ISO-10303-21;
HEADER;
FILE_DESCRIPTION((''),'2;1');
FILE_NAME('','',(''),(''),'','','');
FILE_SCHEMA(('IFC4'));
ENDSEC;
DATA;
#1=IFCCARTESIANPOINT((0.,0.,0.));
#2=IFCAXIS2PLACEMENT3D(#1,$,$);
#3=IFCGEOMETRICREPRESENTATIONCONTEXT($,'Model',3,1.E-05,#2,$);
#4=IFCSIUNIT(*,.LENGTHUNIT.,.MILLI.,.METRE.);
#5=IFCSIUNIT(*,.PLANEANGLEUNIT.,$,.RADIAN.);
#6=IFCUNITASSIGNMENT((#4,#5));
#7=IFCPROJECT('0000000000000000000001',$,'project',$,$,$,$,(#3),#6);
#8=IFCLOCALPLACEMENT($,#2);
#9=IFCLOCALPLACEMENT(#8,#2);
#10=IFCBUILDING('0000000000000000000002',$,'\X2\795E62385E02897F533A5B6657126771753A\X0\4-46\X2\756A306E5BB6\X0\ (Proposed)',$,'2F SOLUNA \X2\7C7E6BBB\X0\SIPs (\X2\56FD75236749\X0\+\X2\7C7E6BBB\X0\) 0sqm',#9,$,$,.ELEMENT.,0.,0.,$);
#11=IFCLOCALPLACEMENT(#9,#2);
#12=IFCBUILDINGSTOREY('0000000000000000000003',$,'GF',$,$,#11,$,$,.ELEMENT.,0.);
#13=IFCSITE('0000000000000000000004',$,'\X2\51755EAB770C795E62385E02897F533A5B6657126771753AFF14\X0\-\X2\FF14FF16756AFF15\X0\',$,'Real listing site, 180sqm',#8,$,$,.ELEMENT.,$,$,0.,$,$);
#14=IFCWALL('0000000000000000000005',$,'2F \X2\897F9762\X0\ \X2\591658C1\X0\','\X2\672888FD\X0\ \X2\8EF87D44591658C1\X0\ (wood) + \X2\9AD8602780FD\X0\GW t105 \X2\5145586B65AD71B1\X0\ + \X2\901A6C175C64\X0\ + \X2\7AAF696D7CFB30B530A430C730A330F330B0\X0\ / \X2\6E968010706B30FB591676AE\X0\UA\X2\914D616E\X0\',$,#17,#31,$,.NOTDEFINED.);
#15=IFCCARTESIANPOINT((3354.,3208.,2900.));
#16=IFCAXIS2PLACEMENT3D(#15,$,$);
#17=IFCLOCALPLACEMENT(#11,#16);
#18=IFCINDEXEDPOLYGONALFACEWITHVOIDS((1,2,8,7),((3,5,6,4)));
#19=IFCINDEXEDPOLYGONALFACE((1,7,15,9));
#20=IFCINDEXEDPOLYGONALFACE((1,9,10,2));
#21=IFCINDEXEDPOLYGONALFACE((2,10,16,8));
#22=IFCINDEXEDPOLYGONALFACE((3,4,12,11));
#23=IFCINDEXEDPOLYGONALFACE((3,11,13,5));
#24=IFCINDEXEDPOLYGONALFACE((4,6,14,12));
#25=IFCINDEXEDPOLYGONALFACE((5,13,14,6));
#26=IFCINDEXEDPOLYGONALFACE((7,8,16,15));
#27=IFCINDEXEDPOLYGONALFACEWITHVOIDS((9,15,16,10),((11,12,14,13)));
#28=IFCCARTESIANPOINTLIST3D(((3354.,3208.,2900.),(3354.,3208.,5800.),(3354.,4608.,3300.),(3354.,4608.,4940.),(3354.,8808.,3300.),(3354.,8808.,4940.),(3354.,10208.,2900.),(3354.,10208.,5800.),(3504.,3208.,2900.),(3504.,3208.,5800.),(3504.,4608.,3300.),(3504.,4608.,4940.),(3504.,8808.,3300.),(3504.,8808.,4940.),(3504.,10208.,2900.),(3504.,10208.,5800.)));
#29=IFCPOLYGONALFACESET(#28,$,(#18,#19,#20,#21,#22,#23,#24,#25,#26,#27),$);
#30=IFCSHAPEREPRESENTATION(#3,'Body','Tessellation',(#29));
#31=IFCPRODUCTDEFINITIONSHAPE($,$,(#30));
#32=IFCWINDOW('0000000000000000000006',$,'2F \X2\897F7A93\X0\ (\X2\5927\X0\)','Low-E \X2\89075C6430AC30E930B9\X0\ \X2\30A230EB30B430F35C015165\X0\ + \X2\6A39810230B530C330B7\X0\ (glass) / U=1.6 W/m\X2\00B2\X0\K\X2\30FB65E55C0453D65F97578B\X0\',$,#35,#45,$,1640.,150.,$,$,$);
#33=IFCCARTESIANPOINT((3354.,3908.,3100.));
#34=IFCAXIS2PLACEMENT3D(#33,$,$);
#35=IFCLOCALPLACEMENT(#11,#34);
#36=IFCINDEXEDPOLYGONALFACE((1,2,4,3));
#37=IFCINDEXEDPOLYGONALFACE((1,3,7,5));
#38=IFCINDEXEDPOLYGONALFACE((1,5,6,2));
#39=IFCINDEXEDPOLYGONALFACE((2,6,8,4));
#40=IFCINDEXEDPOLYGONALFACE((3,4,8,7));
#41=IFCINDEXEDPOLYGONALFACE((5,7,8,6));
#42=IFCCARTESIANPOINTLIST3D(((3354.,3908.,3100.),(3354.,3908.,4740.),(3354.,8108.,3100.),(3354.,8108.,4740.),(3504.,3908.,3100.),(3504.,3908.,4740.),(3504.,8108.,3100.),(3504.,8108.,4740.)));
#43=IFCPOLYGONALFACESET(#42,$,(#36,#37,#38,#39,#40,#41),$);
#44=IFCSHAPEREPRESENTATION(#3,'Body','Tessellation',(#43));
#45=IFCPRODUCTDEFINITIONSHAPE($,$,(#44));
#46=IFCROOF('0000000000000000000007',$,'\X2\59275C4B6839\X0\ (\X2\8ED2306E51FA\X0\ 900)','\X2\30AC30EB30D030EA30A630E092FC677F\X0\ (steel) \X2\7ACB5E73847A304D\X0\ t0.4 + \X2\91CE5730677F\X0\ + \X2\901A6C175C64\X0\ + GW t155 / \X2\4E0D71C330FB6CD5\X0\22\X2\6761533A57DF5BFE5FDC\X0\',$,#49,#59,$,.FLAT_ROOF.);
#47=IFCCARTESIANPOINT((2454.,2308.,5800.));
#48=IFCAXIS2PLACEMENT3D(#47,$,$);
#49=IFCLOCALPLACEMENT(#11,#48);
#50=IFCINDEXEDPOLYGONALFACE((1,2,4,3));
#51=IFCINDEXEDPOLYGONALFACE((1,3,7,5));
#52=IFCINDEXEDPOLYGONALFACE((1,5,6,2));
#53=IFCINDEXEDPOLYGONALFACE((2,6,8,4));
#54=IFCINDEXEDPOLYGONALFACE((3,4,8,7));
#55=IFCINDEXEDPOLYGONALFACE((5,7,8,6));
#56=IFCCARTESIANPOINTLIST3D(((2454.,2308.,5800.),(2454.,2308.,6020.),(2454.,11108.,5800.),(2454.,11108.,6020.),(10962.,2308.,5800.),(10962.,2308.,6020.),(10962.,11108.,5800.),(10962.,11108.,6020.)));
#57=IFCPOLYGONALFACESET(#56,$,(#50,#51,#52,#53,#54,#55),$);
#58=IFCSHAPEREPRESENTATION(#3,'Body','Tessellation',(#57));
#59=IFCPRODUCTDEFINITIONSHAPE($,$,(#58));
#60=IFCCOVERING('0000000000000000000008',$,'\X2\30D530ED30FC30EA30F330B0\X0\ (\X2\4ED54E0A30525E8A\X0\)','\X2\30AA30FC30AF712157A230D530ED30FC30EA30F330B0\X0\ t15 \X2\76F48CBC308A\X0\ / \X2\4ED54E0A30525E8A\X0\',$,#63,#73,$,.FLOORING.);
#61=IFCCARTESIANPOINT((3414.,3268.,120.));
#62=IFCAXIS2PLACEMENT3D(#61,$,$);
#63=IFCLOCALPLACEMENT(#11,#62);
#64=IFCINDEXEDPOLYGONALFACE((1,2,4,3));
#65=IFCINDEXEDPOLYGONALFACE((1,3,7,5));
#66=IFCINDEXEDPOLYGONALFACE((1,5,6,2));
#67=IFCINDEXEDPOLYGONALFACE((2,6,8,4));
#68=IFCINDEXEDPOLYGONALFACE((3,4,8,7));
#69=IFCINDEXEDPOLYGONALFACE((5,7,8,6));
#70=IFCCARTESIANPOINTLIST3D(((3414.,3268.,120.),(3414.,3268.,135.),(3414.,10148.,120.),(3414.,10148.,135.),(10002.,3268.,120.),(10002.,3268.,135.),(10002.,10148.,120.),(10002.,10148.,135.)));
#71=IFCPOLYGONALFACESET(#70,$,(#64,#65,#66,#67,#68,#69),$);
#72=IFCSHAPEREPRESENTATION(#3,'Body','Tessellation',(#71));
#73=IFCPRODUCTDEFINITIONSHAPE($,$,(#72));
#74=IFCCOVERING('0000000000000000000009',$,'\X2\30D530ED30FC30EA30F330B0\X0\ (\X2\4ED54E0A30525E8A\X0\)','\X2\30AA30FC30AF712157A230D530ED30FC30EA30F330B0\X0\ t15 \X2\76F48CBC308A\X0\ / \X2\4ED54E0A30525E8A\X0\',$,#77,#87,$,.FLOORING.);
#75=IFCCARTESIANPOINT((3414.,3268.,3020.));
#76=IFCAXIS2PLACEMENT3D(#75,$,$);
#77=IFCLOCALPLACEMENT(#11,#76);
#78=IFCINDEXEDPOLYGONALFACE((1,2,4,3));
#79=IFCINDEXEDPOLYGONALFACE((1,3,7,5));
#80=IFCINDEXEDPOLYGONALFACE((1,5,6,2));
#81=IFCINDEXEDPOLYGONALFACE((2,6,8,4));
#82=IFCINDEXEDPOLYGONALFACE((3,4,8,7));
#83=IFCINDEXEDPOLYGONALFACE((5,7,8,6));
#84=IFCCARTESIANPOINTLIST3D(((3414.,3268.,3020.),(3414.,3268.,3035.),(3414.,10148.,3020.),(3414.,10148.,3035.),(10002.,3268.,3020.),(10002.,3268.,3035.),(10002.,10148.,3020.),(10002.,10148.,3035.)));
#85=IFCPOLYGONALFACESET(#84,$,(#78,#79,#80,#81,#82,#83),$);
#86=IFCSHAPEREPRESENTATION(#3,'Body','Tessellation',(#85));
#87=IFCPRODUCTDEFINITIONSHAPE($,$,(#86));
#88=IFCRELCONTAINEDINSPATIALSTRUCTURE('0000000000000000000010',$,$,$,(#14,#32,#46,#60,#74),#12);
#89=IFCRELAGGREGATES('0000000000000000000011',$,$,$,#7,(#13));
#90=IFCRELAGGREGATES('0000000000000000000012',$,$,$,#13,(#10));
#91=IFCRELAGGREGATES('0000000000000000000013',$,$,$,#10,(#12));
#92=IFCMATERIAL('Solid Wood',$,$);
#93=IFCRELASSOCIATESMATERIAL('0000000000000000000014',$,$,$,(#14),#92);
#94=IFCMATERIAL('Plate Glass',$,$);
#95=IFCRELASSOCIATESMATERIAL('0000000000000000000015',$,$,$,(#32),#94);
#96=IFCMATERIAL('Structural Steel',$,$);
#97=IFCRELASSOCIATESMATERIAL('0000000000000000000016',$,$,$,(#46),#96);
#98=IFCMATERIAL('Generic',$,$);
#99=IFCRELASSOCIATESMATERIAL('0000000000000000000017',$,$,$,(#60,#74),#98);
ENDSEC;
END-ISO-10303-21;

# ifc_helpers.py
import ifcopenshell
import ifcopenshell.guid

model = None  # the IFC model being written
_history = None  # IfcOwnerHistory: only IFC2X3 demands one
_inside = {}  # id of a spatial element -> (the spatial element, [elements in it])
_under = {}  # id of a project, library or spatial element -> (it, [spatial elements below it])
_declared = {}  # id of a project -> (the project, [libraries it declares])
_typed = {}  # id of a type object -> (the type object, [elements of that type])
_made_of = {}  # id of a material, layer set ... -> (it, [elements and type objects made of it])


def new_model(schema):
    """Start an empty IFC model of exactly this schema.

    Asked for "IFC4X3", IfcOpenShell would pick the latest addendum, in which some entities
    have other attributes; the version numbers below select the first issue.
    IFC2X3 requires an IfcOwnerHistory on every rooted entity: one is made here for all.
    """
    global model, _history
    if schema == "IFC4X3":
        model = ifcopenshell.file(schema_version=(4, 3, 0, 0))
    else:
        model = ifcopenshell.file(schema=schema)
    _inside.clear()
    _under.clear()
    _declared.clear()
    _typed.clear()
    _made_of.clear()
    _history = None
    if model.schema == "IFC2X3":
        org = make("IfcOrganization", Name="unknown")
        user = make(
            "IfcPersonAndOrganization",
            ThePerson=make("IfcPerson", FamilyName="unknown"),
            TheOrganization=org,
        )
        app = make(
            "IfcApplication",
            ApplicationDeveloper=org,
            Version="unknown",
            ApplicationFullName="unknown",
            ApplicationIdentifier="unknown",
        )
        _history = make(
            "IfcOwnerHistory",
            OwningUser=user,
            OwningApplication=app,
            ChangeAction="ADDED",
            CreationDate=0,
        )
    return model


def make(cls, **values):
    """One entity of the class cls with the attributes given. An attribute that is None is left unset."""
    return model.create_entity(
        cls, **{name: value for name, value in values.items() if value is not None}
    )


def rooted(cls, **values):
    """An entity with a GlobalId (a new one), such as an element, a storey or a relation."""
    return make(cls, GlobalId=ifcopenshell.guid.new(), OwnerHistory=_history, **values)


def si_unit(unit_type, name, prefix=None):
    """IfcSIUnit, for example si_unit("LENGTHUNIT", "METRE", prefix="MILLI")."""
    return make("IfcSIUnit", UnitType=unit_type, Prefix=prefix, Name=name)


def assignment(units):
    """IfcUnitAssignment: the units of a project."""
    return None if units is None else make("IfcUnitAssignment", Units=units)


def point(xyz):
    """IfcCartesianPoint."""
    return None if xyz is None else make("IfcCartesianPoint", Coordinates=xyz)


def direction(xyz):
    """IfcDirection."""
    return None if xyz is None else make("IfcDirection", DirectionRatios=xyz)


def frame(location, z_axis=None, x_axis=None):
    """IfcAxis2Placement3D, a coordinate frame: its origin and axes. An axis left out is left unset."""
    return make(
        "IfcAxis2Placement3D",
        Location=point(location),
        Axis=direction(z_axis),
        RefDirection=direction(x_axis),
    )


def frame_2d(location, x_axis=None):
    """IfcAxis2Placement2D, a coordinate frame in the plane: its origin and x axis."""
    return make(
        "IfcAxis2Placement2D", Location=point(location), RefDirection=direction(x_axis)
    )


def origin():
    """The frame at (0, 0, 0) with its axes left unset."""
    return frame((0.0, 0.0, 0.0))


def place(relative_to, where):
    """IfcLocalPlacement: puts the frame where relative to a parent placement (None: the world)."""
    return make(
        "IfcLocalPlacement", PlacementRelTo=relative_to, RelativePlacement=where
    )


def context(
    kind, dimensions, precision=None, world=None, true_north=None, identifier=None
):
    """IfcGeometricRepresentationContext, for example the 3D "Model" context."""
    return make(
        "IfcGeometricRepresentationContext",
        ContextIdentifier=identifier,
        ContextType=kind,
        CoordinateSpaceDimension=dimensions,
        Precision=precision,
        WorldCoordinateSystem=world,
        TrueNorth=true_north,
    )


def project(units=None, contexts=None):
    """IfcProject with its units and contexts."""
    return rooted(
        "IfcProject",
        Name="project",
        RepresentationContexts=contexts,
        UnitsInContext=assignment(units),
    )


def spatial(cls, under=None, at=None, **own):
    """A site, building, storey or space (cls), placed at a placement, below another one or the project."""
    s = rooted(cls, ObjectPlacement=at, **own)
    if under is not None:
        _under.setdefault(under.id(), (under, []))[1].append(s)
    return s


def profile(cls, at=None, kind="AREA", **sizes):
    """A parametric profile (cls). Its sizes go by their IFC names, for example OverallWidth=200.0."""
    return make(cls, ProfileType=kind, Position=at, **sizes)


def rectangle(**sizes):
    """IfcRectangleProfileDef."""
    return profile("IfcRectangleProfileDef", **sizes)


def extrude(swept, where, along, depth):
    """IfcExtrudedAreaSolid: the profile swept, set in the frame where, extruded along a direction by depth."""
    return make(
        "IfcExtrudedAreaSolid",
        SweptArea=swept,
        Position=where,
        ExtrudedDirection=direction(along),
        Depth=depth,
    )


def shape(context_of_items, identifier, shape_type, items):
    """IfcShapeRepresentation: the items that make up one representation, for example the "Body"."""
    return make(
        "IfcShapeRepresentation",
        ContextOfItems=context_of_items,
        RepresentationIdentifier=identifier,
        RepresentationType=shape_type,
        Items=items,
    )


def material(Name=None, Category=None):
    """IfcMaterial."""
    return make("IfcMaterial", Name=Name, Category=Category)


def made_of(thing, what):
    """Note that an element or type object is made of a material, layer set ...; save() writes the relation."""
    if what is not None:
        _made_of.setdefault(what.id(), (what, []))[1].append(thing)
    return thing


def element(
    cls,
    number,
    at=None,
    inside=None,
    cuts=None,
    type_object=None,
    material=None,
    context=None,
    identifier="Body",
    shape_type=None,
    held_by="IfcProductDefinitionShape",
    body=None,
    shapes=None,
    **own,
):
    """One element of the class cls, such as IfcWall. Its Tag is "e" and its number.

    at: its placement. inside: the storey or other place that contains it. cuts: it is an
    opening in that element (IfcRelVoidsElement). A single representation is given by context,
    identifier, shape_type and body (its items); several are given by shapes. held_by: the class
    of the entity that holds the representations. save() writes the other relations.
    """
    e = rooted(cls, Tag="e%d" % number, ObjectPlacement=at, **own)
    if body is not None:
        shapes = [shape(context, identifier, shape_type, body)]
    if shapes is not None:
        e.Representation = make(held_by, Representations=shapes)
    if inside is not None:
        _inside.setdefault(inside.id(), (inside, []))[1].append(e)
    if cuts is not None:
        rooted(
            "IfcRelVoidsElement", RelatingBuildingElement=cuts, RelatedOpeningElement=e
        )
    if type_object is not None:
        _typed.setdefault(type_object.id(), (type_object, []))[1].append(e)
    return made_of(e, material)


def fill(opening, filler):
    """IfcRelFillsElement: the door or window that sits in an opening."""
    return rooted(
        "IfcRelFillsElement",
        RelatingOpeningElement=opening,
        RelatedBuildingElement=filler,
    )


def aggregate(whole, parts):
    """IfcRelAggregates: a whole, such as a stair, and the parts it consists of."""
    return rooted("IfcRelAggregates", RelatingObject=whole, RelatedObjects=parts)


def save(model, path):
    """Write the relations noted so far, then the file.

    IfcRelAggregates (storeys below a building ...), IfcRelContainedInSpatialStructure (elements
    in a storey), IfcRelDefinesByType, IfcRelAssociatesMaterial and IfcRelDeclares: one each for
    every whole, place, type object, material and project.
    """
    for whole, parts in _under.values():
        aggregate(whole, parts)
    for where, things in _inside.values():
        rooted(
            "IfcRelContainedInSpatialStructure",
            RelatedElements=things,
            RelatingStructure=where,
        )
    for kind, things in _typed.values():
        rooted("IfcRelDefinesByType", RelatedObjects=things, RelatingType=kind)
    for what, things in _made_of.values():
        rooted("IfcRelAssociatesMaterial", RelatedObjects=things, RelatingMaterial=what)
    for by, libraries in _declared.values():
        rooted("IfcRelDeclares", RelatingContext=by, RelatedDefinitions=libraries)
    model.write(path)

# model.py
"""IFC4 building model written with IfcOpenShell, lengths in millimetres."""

from ifc_helpers import new_model, si_unit, frame, frame_2d, origin, place, context, project, spatial, rectangle, extrude, material, element, fill, save


model = new_model("IFC4")

# Units and contexts
model_context = context("Model", 3, precision=1e-05, world=origin())
ifc_project = project(units=[si_unit("LENGTHUNIT", "METRE", prefix="MILLI"), si_unit("PLANEANGLEUNIT", "RADIAN")], contexts=[model_context])

# Site, building, storey
site_placement = place(None, origin())
site = spatial("IfcSite", under=ifc_project, at=site_placement, Name="兵庫県神戸市西区学園東町４-４６番５", ObjectType="Real listing site, 180sqm", CompositionType="ELEMENT", RefElevation=0.0)
building_placement = place(site_placement, origin())
building = spatial("IfcBuilding", under=site, at=building_placement, Name="神戸市西区学園東町4-46番の家 (Proposed)", ObjectType="2F SOLUNA 籾殻SIPs (国産杉+籾殻) 0sqm", CompositionType="ELEMENT", ElevationOfRefHeight=0.0, ElevationOfTerrain=0.0)
storey_placement = place(building_placement, origin())
storey = spatial("IfcBuildingStorey", under=building, at=storey_placement, Name="GF", CompositionType="ELEMENT", Elevation=0.0)

# Shared definitions
ifc_material_1 = material(Name="Solid Wood")

# Shared definitions
ifc_material_2 = material(Name="Plate Glass")

# Wall, opening, window
wall_1_placement = place(storey_placement, frame((3354.0, 3208.0, 2900.0)))
wall_1 = element("IfcWall", 1, at=wall_1_placement, inside=storey, material=ifc_material_1, Name="2F 西面 外壁", Description="木製 軸組外壁 (wood) + 高性能GW t105 充填断熱 + 通気層 + 窯業系サイディング / 準耐火・外皮UA配慮", PredefinedType="NOTDEFINED", context=model_context, shape_type="SweptSolid", body=[
    extrude(rectangle(XDim=150.0, YDim=7000.0, at=frame_2d((75.0, 3500.0))), frame((3354.0, 3208.0, 2900.0)), (0.0, 0.0, 1.0), 2900.0),
])
opening_1_placement = place(storey_placement, frame((3354.0, 3908.0, 3100.0)))
opening_1 = element("IfcOpeningElement", 2, at=opening_1_placement, cuts=wall_1, PredefinedType="NOTDEFINED", context=model_context, shape_type="SweptSolid", body=[
    extrude(rectangle(XDim=150.0, YDim=4200.0, at=frame_2d((75.0, 2100.0))), frame((3354.0, 3908.0, 3100.0)), (0.0, 0.0, 1.0), 1640.0),
])
window_1_placement = place(storey_placement, frame((3354.0, 3908.0, 3100.0)))
window_1 = element("IfcWindow", 3, at=window_1_placement, inside=storey, material=ifc_material_2, Name="2F 西窓 (大)", Description="Low-E 複層ガラス アルゴン封入 + 樹脂サッシ (glass) / U=1.6 W/m²K・日射取得型", OverallHeight=1640.0, OverallWidth=150.0, context=model_context, shape_type="SweptSolid", body=[
    extrude(rectangle(XDim=150.0, YDim=4200.0, at=frame_2d((75.0, 2100.0))), frame((3354.0, 3908.0, 3100.0)), (0.0, 0.0, 1.0), 1640.0),
])
fill(opening_1, window_1)

# Roof
ifc_material_3 = material(Name="Structural Steel")
roof_placement = place(storey_placement, frame((2454.0, 2308.0, 5800.0)))
element("IfcRoof", 4, at=roof_placement, inside=storey, material=ifc_material_3, Name="大屋根 (軒の出 900)", Description="ガルバリウム鋼板 (steel) 立平葺き t0.4 + 野地板 + 通気層 + GW t155 / 不燃・法22条区域対応", PredefinedType="FLAT_ROOF", context=model_context, shape_type="SweptSolid", body=[
    extrude(rectangle(XDim=8508.0, YDim=8800.0, at=frame_2d((4254.0, 4400.0))), frame((2454.0, 2308.0, 5800.0)), (0.0, 0.0, 1.0), 220.0),
])

# Coverings
ifc_material_4 = material(Name="Generic")
covering_1_placement = place(storey_placement, frame((3414.0, 3268.0, 120.0)))
element("IfcCovering", 5, at=covering_1_placement, inside=storey, material=ifc_material_4, Name="フローリング (仕上げ床)", Description="オーク無垢フローリング t15 直貼り / 仕上げ床", PredefinedType="FLOORING", context=model_context, shape_type="SweptSolid", body=[
    extrude(rectangle(XDim=6588.0, YDim=6880.0, at=frame_2d((3294.0, 3440.0))), frame((3414.0, 3268.0, 120.0)), (0.0, 0.0, 1.0), 15.0),
])
covering_2_placement = place(storey_placement, frame((3414.0, 3268.0, 3020.0)))
element("IfcCovering", 6, at=covering_2_placement, inside=storey, material=ifc_material_4, Name="フローリング (仕上げ床)", Description="オーク無垢フローリング t15 直貼り / 仕上げ床", PredefinedType="FLOORING", context=model_context, shape_type="SweptSolid", body=[
    extrude(rectangle(XDim=6588.0, YDim=6880.0, at=frame_2d((3294.0, 3440.0))), frame((3414.0, 3268.0, 3020.0)), (0.0, 0.0, 1.0), 15.0),
])

save(model, "model.ifc")
